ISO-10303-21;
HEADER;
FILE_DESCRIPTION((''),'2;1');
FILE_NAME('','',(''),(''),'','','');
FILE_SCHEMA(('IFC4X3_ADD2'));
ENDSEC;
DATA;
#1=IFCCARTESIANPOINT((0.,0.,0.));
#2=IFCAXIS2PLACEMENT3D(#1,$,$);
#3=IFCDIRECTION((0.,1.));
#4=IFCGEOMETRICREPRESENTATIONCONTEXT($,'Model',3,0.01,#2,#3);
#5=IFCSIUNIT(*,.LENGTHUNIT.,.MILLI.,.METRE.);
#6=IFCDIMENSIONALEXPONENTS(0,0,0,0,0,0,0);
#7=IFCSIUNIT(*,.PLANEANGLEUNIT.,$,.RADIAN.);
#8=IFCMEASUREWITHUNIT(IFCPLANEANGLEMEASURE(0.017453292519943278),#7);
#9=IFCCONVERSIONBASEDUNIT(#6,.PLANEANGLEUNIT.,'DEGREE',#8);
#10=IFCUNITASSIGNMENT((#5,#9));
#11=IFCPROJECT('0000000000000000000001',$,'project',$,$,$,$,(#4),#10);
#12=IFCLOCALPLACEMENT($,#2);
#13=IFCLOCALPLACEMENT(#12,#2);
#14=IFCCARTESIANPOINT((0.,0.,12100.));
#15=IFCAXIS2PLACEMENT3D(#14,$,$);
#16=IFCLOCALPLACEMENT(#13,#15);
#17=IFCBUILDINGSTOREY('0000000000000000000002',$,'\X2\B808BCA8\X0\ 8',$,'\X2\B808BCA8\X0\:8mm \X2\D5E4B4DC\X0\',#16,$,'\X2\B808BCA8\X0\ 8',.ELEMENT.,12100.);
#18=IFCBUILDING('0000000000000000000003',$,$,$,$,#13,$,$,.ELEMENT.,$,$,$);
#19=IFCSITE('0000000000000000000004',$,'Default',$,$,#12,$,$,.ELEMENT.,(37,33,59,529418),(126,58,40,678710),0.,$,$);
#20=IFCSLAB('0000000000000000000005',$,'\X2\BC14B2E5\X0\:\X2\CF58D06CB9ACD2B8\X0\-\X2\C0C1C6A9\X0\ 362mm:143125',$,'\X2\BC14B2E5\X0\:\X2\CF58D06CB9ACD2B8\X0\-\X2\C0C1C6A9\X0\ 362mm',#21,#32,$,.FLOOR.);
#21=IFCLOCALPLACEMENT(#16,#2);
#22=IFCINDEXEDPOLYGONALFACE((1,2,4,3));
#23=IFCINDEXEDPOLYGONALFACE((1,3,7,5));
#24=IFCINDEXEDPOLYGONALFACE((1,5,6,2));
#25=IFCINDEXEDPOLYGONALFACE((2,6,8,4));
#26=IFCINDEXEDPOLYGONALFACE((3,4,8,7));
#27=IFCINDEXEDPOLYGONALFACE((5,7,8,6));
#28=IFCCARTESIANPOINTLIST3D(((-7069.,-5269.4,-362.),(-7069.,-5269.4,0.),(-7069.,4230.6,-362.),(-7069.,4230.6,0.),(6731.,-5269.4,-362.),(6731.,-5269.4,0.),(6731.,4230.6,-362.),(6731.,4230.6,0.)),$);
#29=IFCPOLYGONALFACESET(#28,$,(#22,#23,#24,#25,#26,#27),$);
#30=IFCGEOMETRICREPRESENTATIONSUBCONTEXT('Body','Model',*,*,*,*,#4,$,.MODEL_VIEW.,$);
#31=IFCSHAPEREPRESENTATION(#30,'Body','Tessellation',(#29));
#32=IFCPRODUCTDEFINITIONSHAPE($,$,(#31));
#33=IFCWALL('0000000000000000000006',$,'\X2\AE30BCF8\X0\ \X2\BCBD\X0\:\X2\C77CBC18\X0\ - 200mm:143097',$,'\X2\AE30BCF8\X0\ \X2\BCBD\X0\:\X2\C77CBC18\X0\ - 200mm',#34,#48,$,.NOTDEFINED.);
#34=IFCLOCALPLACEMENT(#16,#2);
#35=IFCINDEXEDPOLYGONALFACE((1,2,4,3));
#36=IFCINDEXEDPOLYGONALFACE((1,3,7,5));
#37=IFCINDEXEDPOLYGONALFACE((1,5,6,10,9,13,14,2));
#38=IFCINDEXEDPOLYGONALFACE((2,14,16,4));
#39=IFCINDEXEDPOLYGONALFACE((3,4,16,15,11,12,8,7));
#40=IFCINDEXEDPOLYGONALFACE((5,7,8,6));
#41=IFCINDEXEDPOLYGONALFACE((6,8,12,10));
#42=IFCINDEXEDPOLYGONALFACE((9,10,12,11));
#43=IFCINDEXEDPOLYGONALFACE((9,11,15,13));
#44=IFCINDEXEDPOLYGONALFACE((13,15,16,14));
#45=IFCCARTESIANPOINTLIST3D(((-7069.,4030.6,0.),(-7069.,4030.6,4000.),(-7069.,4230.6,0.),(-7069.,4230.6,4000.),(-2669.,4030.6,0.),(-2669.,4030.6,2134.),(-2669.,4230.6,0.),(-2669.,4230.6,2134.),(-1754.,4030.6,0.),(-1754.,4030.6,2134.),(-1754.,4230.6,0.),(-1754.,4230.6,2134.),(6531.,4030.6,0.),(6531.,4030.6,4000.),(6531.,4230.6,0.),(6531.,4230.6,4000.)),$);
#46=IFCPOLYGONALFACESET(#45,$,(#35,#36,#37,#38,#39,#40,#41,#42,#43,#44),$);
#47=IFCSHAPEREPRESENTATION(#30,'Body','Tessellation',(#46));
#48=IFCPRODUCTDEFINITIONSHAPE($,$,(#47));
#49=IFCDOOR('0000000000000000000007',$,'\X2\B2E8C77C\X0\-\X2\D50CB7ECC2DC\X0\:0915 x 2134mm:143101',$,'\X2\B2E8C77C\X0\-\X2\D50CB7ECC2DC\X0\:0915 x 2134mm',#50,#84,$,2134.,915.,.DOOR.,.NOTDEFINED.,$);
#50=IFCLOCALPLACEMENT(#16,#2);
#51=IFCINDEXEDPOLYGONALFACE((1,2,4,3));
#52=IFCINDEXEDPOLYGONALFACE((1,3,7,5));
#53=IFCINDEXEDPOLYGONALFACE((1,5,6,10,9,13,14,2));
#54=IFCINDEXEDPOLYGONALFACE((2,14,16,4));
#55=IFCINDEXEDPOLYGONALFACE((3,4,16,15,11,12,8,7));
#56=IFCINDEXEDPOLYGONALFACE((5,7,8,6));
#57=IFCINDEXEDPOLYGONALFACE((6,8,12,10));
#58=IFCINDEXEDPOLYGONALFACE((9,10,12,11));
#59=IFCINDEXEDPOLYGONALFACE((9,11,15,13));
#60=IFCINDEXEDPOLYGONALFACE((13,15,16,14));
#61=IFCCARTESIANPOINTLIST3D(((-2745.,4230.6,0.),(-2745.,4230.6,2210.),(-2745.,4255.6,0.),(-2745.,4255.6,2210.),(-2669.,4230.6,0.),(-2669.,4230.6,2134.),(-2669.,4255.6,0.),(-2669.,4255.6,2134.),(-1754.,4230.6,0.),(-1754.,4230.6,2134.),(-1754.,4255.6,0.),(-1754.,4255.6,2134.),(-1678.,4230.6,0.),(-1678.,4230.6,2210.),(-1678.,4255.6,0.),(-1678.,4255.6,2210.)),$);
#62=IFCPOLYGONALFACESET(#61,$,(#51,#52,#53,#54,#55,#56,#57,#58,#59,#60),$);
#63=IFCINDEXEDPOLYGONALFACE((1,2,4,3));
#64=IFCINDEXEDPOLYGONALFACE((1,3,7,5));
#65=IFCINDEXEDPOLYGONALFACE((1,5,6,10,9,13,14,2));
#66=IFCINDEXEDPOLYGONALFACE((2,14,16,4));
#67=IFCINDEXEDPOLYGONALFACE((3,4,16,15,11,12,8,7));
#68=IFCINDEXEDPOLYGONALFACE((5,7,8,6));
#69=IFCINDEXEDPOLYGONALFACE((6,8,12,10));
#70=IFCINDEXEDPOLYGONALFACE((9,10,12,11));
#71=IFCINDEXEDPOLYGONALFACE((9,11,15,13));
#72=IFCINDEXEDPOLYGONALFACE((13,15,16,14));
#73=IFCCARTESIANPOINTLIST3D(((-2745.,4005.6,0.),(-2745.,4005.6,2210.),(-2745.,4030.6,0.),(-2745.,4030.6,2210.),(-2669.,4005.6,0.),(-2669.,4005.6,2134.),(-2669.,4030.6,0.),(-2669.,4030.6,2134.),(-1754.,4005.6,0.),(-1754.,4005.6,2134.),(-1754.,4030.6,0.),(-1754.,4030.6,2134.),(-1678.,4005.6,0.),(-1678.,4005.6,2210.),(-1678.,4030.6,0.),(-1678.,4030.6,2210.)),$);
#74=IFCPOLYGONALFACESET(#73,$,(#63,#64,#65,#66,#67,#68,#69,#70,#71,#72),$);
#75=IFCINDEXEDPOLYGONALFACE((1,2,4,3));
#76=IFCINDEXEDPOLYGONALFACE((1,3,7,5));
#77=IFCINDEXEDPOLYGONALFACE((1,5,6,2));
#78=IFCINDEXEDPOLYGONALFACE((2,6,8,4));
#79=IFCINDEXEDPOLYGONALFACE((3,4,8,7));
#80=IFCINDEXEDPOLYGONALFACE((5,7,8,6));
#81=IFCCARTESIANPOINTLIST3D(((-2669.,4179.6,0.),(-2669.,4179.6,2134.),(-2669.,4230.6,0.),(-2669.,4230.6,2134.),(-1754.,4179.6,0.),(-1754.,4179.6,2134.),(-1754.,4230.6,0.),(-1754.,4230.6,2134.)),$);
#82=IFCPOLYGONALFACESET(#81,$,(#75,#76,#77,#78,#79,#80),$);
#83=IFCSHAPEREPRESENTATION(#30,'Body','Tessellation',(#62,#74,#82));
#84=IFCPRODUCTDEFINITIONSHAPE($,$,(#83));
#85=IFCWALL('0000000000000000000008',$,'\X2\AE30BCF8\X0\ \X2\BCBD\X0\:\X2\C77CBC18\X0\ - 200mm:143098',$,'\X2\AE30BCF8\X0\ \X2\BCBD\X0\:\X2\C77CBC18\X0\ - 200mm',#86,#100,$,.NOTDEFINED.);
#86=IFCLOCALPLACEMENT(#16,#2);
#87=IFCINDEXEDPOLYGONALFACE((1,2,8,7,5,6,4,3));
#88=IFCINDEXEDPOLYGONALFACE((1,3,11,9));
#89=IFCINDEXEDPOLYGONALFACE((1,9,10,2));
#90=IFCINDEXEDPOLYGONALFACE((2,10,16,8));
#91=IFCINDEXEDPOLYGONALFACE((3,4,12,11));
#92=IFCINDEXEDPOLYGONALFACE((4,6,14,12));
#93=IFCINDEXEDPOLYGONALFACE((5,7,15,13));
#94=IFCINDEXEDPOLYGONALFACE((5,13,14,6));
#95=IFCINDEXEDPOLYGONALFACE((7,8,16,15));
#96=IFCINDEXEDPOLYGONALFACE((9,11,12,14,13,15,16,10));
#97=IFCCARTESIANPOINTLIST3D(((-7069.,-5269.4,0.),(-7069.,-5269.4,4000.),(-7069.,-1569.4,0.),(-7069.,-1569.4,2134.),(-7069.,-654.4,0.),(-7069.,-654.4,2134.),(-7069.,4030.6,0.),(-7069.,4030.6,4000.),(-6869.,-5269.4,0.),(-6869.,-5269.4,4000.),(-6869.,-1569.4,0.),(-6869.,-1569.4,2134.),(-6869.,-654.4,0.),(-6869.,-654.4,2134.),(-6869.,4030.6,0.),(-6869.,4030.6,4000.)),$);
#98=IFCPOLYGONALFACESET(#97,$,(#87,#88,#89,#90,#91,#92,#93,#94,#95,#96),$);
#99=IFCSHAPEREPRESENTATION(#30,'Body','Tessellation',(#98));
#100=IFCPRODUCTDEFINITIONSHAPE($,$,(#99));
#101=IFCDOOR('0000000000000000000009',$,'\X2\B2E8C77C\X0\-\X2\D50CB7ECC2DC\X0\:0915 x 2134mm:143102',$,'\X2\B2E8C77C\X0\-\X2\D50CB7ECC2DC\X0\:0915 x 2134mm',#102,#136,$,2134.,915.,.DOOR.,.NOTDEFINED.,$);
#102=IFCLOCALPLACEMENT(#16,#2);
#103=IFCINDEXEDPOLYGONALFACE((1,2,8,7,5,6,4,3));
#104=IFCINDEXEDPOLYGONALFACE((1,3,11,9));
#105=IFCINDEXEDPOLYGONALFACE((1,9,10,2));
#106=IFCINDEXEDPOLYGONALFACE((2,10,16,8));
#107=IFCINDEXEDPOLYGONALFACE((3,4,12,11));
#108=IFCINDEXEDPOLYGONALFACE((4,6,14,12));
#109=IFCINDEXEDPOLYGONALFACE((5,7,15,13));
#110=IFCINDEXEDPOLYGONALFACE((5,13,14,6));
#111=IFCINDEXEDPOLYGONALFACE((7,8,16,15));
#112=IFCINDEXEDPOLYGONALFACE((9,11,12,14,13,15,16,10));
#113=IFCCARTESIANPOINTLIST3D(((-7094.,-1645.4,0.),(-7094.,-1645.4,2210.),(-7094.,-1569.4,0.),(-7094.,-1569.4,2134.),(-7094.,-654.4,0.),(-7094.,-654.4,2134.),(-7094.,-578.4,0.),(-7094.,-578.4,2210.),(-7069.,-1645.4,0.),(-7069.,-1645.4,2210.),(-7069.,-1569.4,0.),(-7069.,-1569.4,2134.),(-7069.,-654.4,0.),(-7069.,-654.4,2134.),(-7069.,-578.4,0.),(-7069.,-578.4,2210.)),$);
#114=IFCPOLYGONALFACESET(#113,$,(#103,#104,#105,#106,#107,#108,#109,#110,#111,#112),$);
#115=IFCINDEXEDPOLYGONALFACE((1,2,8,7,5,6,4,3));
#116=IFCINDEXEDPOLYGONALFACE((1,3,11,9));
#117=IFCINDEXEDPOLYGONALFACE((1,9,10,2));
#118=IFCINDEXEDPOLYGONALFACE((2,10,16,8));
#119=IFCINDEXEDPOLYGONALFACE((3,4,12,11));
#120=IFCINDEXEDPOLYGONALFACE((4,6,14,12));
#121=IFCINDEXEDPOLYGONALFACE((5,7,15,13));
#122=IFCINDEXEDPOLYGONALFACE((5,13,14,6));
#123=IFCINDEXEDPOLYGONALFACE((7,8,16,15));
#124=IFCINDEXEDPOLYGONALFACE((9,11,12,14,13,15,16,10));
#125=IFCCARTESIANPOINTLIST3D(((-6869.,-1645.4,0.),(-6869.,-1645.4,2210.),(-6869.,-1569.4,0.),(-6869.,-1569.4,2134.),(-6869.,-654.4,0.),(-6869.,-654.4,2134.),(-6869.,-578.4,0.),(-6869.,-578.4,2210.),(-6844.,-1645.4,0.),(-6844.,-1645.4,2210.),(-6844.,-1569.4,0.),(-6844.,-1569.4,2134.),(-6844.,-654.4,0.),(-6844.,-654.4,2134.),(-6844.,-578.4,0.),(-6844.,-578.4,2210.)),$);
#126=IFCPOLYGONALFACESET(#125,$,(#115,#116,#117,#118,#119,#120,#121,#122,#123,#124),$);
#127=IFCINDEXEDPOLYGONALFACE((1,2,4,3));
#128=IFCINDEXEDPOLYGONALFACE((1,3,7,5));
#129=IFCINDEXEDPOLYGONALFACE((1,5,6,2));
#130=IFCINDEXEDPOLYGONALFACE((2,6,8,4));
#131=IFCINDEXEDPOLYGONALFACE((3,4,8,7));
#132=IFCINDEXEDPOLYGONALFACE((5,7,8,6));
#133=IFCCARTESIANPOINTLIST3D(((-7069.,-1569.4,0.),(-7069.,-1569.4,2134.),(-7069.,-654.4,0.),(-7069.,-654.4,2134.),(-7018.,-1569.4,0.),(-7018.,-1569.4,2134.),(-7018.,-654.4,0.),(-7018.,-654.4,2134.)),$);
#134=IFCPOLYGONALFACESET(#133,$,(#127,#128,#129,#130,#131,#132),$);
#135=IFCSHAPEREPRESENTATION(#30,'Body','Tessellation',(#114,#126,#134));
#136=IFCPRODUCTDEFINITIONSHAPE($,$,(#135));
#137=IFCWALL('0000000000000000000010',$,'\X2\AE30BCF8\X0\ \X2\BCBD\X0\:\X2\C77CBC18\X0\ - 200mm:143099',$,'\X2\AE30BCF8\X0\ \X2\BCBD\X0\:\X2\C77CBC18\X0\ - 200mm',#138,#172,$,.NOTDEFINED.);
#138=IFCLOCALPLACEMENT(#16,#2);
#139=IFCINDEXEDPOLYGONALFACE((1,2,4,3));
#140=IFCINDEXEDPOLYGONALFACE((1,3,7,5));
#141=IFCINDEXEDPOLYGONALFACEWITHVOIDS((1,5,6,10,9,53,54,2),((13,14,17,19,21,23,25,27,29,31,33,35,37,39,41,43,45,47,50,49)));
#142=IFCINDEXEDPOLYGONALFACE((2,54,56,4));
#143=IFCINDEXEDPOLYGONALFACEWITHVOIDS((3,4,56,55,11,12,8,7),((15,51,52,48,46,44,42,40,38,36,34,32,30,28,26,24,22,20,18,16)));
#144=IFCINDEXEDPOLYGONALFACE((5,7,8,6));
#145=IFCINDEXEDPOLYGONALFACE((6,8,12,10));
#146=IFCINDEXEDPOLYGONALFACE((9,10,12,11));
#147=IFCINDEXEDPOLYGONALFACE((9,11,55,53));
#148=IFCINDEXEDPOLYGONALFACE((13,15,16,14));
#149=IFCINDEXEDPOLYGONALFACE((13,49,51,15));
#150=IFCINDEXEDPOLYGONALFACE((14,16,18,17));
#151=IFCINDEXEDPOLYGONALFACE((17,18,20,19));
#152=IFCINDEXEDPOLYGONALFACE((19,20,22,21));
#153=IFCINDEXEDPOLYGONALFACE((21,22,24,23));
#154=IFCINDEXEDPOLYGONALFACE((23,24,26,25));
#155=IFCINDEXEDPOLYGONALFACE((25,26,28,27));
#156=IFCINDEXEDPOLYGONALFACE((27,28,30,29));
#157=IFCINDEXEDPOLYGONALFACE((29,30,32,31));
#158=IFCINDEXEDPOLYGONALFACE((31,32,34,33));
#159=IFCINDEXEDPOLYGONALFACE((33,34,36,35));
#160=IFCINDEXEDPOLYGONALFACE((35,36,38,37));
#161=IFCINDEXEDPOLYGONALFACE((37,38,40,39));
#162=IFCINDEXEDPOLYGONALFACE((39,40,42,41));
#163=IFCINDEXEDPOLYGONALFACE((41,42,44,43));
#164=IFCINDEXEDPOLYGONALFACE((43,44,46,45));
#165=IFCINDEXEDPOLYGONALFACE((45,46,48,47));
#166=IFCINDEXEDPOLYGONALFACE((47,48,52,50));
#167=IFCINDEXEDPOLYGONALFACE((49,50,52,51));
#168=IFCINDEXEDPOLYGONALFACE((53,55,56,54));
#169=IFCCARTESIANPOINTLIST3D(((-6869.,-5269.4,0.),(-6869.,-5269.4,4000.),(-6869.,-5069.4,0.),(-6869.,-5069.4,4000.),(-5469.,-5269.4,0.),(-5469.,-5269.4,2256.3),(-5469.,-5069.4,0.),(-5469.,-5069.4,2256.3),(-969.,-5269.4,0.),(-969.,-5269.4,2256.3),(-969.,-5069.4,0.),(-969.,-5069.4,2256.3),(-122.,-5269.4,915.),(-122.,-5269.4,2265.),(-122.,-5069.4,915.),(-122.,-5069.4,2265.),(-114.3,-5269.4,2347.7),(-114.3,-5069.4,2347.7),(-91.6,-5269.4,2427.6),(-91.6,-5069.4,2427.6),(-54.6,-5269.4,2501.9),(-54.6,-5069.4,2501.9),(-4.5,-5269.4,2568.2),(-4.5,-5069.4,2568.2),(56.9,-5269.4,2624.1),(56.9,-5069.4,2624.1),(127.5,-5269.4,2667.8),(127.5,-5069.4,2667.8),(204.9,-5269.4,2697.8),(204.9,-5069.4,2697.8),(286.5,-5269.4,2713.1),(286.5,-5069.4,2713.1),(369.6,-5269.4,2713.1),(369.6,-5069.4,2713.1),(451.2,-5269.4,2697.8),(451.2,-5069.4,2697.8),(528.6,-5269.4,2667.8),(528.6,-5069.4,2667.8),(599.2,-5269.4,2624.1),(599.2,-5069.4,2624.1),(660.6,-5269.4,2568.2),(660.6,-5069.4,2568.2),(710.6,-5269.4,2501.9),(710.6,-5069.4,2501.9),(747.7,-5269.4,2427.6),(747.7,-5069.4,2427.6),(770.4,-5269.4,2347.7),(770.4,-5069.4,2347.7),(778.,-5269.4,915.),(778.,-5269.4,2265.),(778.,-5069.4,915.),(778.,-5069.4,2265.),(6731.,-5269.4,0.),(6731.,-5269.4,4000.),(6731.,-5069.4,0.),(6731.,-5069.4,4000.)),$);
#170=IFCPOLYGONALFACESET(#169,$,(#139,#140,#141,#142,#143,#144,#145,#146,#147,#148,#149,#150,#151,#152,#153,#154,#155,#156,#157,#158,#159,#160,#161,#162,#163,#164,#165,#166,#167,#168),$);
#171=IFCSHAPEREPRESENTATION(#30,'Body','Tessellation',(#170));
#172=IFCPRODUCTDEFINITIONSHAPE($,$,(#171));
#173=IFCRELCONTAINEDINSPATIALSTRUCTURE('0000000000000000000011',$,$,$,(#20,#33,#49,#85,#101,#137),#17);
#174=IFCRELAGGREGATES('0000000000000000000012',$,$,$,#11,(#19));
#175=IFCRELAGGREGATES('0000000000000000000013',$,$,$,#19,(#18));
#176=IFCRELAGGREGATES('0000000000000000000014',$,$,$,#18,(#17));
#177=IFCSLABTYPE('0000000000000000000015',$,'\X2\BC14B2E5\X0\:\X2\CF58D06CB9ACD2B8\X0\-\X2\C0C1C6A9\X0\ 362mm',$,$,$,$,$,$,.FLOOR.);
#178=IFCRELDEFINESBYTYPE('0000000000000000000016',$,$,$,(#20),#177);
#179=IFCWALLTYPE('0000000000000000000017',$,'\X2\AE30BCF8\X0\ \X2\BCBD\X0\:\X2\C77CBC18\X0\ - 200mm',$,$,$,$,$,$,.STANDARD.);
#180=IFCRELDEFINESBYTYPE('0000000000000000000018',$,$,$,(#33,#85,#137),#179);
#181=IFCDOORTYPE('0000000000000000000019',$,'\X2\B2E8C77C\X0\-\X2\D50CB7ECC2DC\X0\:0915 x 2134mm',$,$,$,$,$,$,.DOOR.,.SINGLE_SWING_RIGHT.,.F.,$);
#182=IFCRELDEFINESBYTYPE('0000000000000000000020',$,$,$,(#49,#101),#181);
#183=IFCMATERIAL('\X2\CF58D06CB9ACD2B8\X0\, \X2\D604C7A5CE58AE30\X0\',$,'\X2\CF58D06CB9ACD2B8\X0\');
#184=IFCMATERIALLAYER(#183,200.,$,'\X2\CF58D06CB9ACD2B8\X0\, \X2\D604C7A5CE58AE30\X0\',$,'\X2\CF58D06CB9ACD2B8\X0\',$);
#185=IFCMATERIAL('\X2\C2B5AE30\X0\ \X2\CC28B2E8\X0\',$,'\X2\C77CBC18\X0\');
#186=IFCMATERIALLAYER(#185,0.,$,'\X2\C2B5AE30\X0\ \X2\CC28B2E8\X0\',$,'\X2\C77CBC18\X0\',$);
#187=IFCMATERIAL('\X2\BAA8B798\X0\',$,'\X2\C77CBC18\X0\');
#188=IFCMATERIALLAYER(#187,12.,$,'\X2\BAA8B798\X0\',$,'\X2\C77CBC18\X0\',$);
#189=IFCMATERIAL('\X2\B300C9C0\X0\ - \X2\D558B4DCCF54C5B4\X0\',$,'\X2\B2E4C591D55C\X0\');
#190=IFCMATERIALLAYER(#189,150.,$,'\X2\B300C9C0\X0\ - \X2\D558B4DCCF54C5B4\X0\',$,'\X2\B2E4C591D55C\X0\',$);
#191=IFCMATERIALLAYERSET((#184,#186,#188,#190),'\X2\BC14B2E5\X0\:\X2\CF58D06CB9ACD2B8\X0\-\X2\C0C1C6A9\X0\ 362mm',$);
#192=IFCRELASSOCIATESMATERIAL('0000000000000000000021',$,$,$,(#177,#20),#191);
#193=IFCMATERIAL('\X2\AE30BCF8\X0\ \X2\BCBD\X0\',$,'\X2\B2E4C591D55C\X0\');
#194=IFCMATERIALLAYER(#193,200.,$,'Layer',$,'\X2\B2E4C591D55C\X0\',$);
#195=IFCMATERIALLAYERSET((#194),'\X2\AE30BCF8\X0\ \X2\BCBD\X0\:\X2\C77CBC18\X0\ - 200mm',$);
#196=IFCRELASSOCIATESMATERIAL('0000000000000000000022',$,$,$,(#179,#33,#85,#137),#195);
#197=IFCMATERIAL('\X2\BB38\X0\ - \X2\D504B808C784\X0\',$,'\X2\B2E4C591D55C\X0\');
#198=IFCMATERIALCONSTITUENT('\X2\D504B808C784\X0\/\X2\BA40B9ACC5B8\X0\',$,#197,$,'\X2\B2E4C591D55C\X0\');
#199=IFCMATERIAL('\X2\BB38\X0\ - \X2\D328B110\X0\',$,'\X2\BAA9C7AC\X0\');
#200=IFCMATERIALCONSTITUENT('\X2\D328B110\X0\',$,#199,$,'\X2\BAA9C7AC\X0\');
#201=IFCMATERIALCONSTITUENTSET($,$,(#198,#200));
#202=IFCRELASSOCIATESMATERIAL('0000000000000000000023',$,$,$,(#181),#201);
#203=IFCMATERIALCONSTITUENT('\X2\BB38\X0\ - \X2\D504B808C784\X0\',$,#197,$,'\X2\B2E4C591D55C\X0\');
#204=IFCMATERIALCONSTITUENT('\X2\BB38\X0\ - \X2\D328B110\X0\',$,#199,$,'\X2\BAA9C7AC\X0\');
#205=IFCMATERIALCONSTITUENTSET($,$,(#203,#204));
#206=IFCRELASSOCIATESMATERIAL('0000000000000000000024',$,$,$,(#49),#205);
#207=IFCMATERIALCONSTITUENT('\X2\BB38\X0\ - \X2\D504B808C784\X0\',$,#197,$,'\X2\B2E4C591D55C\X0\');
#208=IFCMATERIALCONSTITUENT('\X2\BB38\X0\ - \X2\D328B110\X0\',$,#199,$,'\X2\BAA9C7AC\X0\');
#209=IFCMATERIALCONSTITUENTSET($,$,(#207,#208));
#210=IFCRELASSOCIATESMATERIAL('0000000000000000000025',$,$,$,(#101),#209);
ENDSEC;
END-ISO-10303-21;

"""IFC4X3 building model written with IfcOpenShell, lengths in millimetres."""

from ifc_helpers import new_model, entity, si_unit, converted_unit, direction, frame, frame_2d, origin, origin_2d_with_axis, place, context, subcontext, project, spatial, polyline, circle_curve, parameter, trimmed, segment, composite_curve, rectangle, outline, extrude, source, transform, mapped, material, layer, layer_set, layer_usage, constituent, constituent_set, type_object, type_shapes, element, fill, save


model = new_model("IFC4X3")

# Units and contexts
model_context = context("Model", 3, precision=0.01, world=origin(), true_north=direction((0.0, 1.0)))
body_context = subcontext(model_context, "Body", "Model", "MODEL_VIEW")
ifc_project = project(units=[si_unit("LENGTHUNIT", "METRE", prefix="MILLI"), converted_unit("PLANEANGLEUNIT", "DEGREE", entity("IfcPlaneAngleMeasure", 0.017453292519943278), si_unit("PLANEANGLEUNIT", "RADIAN"), dimensions=[0, 0, 0, 0, 0, 0, 0])], contexts=[model_context])

# Site, building, storey
site_placement = place(None, origin())
site = spatial("IfcSite", under=ifc_project, at=site_placement, Name="Default", CompositionType="ELEMENT", RefLatitude=(37, 33, 59, 529418), RefLongitude=(126, 58, 40, 678710), RefElevation=0.0)
building_placement = place(site_placement, origin())
building = spatial("IfcBuilding", under=site, at=building_placement, CompositionType="ELEMENT")
storey_placement = place(building_placement, frame((0.0, 0.0, 12100.0)))
storey = spatial("IfcBuildingStorey", under=building, at=storey_placement, Name="레벨 8", ObjectType="레벨:8mm 헤드", LongName="레벨 8", CompositionType="ELEMENT", Elevation=12100.0)

# Slab
ifc_material_1 = material(Name="콘크리트, 현장치기", Category="콘크리트")
ifc_layer_1 = layer(ifc_material_1, 200.0, Name="콘크리트, 현장치기", Category="콘크리트")
ifc_material_2 = material(Name="습기 차단", Category="일반")
ifc_layer_2 = layer(ifc_material_2, 0.0, Name="습기 차단", Category="일반")
ifc_material_3 = material(Name="모래", Category="일반")
ifc_layer_3 = layer(ifc_material_3, 12.0, Name="모래", Category="일반")
ifc_material_4 = material(Name="대지 - 하드코어", Category="다양한")
ifc_layer_4 = layer(ifc_material_4, 150.0, Name="대지 - 하드코어", Category="다양한")
ifc_layer_set_1 = layer_set([ifc_layer_1, ifc_layer_2, ifc_layer_3, ifc_layer_4], Name="바닥:콘크리트-상용 362mm")
ifc_layer_usage_1 = layer_usage(ifc_layer_set_1, "AXIS3", "POSITIVE", 0.0)
slab_type = type_object("IfcSlabType", Name="바닥:콘크리트-상용 362mm", PredefinedType="FLOOR", material=ifc_layer_set_1)
slab_placement = place(storey_placement, origin())
element("IfcSlab", 1, at=slab_placement, inside=storey, type_object=slab_type, material=ifc_layer_usage_1, Name="바닥:콘크리트-상용 362mm:143125", ObjectType="바닥:콘크리트-상용 362mm", PredefinedType="FLOOR", context=body_context, shape_type="SweptSolid", body=[
    extrude(rectangle(XDim=9500.0, YDim=13800.0, at=origin_2d_with_axis()), frame((-169.0, -519.4, 0.0), z_axis=(0.0, 0.0, -1.0), x_axis=(0.0, 1.0, 0.0)), (0.0, 0.0, 1.0), 362.0),
])

# Walls, openings, doors
ifc_material_5 = material(Name="기본 벽", Category="다양한")
ifc_layer_5 = layer(ifc_material_5, 200.0, Name="Layer", Category="다양한")
ifc_layer_set_2 = layer_set([ifc_layer_5], Name="기본 벽:일반 - 200mm")
wall_type = type_object("IfcWallType", Name="기본 벽:일반 - 200mm", PredefinedType="STANDARD", material=ifc_layer_set_2)
wall_1_placement = place(storey_placement, frame((-7069.0, 4130.6, 0.0)))
wall_1 = element("IfcWall", 2, at=wall_1_placement, inside=storey, type_object=wall_type, material=ifc_layer_set_2, Name="기본 벽:일반 - 200mm:143097", ObjectType="기본 벽:일반 - 200mm", PredefinedType="NOTDEFINED", context=body_context, shape_type="SweptSolid", body=[
    extrude(rectangle(XDim=13600.0, YDim=200.0, at=frame_2d((6800.0, 0.0), x_axis=(1.0, 0.0))), origin(), (0.0, 0.0, 1.0), 4000.0),
])
opening_1_placement = place(wall_1_placement, frame((4400.0, -100.0, 0.0)))
opening_1 = element("IfcOpeningElement", 3, at=opening_1_placement, cuts=wall_1, PredefinedType="OPENING", context=body_context, shape_type="SweptSolid", body=[
    extrude(rectangle(XDim=915.0, YDim=2134.0, at=frame_2d((1067.0, 457.5), x_axis=(0.0, 1.0))), frame((0.0, 0.0, 0.0), z_axis=(0.0, 1.0, 0.0), x_axis=(0.0, 0.0, 1.0)), (0.0, 0.0, 1.0), 200.0),
])
ifc_material_6 = material(Name="문 - 프레임", Category="다양한")
ifc_constituent_1 = constituent(ifc_material_6, Name="문 - 프레임", Category="다양한")
ifc_material_7 = material(Name="문 - 패널", Category="목재")
ifc_constituent_2 = constituent(ifc_material_7, Name="문 - 패널", Category="목재")
ifc_constituent_set_1 = constituent_set(constituents=[ifc_constituent_1, ifc_constituent_2])
ifc_constituent_3 = constituent(ifc_material_6, Name="프레임/멀리언", Category="다양한")
ifc_constituent_4 = constituent(ifc_material_7, Name="패널", Category="목재")
ifc_constituent_set_2 = constituent_set(constituents=[ifc_constituent_3, ifc_constituent_4])
door_type = type_object("IfcDoorType", Name="단일-플러시:0915 x 2134mm", OperationType="SINGLE_SWING_RIGHT", ParameterTakesPrecedence=False, PredefinedType="DOOR", material=ifc_constituent_set_2)
shared_shape_1 = source(origin(), body_context, "Body", "SweptSolid", [
    extrude(outline(polyline([(-533.5, -1124.0), (533.5, -1124.0), (533.5, 1086.0), (457.5, 1086.0), (457.5, -1048.0), (-457.5, -1048.0), (-457.5, 1086.0), (-533.5, 1086.0), (-533.5, -1124.0)])), frame((457.5, 200.0, 1086.0), z_axis=(0.0, 1.0, 0.0), x_axis=(1.0, 0.0, 0.0)), (0.0, 0.0, 1.0), 25.0),
    extrude(outline(polyline([(-1124.0, -533.5), (1086.0, -533.5), (1086.0, -457.5), (-1048.0, -457.5), (-1048.0, 457.5), (1086.0, 457.5), (1086.0, 533.5), (-1124.0, 533.5), (-1124.0, -533.5)])), frame((457.5, -25.0, 1086.0), z_axis=(0.0, 1.0, 0.0), x_axis=(0.0, 0.0, -1.0)), (0.0, 0.0, 1.0), 25.0),
    extrude(rectangle(XDim=51.0, YDim=915.0, at=frame_2d((0.0, 0.0), x_axis=(1.0, 0.0))), frame((457.5, 174.5, 0.0), z_axis=(0.0, 0.0, 1.0), x_axis=(0.0, 1.0, 0.0)), (0.0, 0.0, 1.0), 2134.0),
])
type_shapes(door_type, [shared_shape_1])
door_1_placement = place(opening_1_placement, origin())
door_1 = element("IfcDoor", 4, at=door_1_placement, inside=storey, type_object=door_type, material=ifc_constituent_set_1, Name="단일-플러시:0915 x 2134mm:143101", ObjectType="단일-플러시:0915 x 2134mm", OperationType="NOTDEFINED", OverallHeight=2134.0, OverallWidth=915.0, PredefinedType="DOOR", context=body_context, shape_type="MappedRepresentation", body=[
    mapped(shared_shape_1, transform((0.0, 0.0, 0.0), scale=1.0)),
])
fill(opening_1, door_1)
wall_2_placement = place(storey_placement, frame((-6969.0, -5269.4, 0.0), z_axis=(0.0, 0.0, 1.0), x_axis=(0.0, 1.0, 0.0)))
wall_2 = element("IfcWall", 5, at=wall_2_placement, inside=storey, type_object=wall_type, material=ifc_layer_set_2, Name="기본 벽:일반 - 200mm:143098", ObjectType="기본 벽:일반 - 200mm", PredefinedType="NOTDEFINED", context=body_context, shape_type="SweptSolid", body=[
    extrude(rectangle(XDim=9300.0, YDim=200.0, at=frame_2d((4650.0, 0.0), x_axis=(1.0, 0.0))), origin(), (0.0, 0.0, 1.0), 4000.0),
])
opening_2_placement = place(wall_2_placement, frame((3700.0, -100.0, 0.0)))
opening_2 = element("IfcOpeningElement", 6, at=opening_2_placement, cuts=wall_2, PredefinedType="OPENING", context=body_context, shape_type="SweptSolid", body=[
    extrude(rectangle(XDim=915.0, YDim=2134.0, at=frame_2d((1067.0, 457.5), x_axis=(0.0, 1.0))), frame((0.0, 0.0, 0.0), z_axis=(0.0, 1.0, 0.0), x_axis=(0.0, 0.0, 1.0)), (0.0, 0.0, 1.0), 200.0),
])
ifc_constituent_5 = constituent(ifc_material_6, Name="문 - 프레임", Category="다양한")
ifc_constituent_6 = constituent(ifc_material_7, Name="문 - 패널", Category="목재")
ifc_constituent_set_3 = constituent_set(constituents=[ifc_constituent_5, ifc_constituent_6])
door_2_placement = place(opening_2_placement, origin())
door_2 = element("IfcDoor", 7, at=door_2_placement, inside=storey, type_object=door_type, material=ifc_constituent_set_3, Name="단일-플러시:0915 x 2134mm:143102", ObjectType="단일-플러시:0915 x 2134mm", OperationType="NOTDEFINED", OverallHeight=2134.0, OverallWidth=915.0, PredefinedType="DOOR", context=body_context, shape_type="MappedRepresentation", body=[
    mapped(shared_shape_1, transform((0.0, 0.0, 0.0), scale=1.0)),
])
fill(opening_2, door_2)

# Wall, openings
wall_3_placement = place(storey_placement, frame((6731.0, -5169.4, 0.0), z_axis=(0.0, 0.0, 1.0), x_axis=(-1.0, 0.0, 0.0)))
wall_3 = element("IfcWall", 8, at=wall_3_placement, inside=storey, type_object=wall_type, material=ifc_layer_set_2, Name="기본 벽:일반 - 200mm:143099", ObjectType="기본 벽:일반 - 200mm", PredefinedType="NOTDEFINED", context=body_context, shape_type="SweptSolid", body=[
    extrude(rectangle(XDim=13600.0, YDim=200.0, at=frame_2d((6800.0, 0.0), x_axis=(1.0, 0.0))), origin(), (0.0, 0.0, 1.0), 4000.0),
])
opening_3_placement = place(wall_3_placement, frame((12200.0, 252.4, -12100.0)))
element("IfcOpeningElement", 9, at=opening_3_placement, cuts=wall_3, PredefinedType="OPENING", context=body_context, shape_type="SweptSolid", body=[
    extrude(rectangle(XDim=14356.3, YDim=4500.0, at=frame_2d((0.0, 0.0), x_axis=(0.0, 1.0))), frame((-2250.0, -504.8, 7178.2), z_axis=(0.0, 1.0, 0.0), x_axis=(-1.0, 0.0, 0.0)), (0.0, 0.0, 1.0), 504.8),
])
opening_4_placement = place(wall_3_placement, frame((5953.0, -100.0, 915.0)))
element("IfcOpeningElement", 10, at=opening_4_placement, cuts=wall_3, PredefinedType="OPENING", context=body_context, shape_type="SweptSolid", body=[
    extrude(outline(composite_curve([segment(polyline([(1350.0, 900.0), (0.0, 900.0)]), True, "CONTINUOUS"), segment(polyline([(0.0, 900.0), (0.0, 0.0)]), True, "CONTINUOUS"), segment(polyline([(0.0, 0.0), (1350.0, 0.0)]), True, "CONTINUOUS"), segment(trimmed(circle_curve(frame_2d((1350.0, 450.0), x_axis=(0.0, 1.0)), 450.0), [parameter(180.0)], [parameter(0.0)], True, "PARAMETER"), True, "CONTINUOUS")], self_intersect=False)), frame((0.0, 0.0, 0.0), z_axis=(0.0, 1.0, 0.0), x_axis=(0.0, 0.0, 1.0)), (0.0, 0.0, 1.0), 200.0),
])

save(model, "model.ifc")
